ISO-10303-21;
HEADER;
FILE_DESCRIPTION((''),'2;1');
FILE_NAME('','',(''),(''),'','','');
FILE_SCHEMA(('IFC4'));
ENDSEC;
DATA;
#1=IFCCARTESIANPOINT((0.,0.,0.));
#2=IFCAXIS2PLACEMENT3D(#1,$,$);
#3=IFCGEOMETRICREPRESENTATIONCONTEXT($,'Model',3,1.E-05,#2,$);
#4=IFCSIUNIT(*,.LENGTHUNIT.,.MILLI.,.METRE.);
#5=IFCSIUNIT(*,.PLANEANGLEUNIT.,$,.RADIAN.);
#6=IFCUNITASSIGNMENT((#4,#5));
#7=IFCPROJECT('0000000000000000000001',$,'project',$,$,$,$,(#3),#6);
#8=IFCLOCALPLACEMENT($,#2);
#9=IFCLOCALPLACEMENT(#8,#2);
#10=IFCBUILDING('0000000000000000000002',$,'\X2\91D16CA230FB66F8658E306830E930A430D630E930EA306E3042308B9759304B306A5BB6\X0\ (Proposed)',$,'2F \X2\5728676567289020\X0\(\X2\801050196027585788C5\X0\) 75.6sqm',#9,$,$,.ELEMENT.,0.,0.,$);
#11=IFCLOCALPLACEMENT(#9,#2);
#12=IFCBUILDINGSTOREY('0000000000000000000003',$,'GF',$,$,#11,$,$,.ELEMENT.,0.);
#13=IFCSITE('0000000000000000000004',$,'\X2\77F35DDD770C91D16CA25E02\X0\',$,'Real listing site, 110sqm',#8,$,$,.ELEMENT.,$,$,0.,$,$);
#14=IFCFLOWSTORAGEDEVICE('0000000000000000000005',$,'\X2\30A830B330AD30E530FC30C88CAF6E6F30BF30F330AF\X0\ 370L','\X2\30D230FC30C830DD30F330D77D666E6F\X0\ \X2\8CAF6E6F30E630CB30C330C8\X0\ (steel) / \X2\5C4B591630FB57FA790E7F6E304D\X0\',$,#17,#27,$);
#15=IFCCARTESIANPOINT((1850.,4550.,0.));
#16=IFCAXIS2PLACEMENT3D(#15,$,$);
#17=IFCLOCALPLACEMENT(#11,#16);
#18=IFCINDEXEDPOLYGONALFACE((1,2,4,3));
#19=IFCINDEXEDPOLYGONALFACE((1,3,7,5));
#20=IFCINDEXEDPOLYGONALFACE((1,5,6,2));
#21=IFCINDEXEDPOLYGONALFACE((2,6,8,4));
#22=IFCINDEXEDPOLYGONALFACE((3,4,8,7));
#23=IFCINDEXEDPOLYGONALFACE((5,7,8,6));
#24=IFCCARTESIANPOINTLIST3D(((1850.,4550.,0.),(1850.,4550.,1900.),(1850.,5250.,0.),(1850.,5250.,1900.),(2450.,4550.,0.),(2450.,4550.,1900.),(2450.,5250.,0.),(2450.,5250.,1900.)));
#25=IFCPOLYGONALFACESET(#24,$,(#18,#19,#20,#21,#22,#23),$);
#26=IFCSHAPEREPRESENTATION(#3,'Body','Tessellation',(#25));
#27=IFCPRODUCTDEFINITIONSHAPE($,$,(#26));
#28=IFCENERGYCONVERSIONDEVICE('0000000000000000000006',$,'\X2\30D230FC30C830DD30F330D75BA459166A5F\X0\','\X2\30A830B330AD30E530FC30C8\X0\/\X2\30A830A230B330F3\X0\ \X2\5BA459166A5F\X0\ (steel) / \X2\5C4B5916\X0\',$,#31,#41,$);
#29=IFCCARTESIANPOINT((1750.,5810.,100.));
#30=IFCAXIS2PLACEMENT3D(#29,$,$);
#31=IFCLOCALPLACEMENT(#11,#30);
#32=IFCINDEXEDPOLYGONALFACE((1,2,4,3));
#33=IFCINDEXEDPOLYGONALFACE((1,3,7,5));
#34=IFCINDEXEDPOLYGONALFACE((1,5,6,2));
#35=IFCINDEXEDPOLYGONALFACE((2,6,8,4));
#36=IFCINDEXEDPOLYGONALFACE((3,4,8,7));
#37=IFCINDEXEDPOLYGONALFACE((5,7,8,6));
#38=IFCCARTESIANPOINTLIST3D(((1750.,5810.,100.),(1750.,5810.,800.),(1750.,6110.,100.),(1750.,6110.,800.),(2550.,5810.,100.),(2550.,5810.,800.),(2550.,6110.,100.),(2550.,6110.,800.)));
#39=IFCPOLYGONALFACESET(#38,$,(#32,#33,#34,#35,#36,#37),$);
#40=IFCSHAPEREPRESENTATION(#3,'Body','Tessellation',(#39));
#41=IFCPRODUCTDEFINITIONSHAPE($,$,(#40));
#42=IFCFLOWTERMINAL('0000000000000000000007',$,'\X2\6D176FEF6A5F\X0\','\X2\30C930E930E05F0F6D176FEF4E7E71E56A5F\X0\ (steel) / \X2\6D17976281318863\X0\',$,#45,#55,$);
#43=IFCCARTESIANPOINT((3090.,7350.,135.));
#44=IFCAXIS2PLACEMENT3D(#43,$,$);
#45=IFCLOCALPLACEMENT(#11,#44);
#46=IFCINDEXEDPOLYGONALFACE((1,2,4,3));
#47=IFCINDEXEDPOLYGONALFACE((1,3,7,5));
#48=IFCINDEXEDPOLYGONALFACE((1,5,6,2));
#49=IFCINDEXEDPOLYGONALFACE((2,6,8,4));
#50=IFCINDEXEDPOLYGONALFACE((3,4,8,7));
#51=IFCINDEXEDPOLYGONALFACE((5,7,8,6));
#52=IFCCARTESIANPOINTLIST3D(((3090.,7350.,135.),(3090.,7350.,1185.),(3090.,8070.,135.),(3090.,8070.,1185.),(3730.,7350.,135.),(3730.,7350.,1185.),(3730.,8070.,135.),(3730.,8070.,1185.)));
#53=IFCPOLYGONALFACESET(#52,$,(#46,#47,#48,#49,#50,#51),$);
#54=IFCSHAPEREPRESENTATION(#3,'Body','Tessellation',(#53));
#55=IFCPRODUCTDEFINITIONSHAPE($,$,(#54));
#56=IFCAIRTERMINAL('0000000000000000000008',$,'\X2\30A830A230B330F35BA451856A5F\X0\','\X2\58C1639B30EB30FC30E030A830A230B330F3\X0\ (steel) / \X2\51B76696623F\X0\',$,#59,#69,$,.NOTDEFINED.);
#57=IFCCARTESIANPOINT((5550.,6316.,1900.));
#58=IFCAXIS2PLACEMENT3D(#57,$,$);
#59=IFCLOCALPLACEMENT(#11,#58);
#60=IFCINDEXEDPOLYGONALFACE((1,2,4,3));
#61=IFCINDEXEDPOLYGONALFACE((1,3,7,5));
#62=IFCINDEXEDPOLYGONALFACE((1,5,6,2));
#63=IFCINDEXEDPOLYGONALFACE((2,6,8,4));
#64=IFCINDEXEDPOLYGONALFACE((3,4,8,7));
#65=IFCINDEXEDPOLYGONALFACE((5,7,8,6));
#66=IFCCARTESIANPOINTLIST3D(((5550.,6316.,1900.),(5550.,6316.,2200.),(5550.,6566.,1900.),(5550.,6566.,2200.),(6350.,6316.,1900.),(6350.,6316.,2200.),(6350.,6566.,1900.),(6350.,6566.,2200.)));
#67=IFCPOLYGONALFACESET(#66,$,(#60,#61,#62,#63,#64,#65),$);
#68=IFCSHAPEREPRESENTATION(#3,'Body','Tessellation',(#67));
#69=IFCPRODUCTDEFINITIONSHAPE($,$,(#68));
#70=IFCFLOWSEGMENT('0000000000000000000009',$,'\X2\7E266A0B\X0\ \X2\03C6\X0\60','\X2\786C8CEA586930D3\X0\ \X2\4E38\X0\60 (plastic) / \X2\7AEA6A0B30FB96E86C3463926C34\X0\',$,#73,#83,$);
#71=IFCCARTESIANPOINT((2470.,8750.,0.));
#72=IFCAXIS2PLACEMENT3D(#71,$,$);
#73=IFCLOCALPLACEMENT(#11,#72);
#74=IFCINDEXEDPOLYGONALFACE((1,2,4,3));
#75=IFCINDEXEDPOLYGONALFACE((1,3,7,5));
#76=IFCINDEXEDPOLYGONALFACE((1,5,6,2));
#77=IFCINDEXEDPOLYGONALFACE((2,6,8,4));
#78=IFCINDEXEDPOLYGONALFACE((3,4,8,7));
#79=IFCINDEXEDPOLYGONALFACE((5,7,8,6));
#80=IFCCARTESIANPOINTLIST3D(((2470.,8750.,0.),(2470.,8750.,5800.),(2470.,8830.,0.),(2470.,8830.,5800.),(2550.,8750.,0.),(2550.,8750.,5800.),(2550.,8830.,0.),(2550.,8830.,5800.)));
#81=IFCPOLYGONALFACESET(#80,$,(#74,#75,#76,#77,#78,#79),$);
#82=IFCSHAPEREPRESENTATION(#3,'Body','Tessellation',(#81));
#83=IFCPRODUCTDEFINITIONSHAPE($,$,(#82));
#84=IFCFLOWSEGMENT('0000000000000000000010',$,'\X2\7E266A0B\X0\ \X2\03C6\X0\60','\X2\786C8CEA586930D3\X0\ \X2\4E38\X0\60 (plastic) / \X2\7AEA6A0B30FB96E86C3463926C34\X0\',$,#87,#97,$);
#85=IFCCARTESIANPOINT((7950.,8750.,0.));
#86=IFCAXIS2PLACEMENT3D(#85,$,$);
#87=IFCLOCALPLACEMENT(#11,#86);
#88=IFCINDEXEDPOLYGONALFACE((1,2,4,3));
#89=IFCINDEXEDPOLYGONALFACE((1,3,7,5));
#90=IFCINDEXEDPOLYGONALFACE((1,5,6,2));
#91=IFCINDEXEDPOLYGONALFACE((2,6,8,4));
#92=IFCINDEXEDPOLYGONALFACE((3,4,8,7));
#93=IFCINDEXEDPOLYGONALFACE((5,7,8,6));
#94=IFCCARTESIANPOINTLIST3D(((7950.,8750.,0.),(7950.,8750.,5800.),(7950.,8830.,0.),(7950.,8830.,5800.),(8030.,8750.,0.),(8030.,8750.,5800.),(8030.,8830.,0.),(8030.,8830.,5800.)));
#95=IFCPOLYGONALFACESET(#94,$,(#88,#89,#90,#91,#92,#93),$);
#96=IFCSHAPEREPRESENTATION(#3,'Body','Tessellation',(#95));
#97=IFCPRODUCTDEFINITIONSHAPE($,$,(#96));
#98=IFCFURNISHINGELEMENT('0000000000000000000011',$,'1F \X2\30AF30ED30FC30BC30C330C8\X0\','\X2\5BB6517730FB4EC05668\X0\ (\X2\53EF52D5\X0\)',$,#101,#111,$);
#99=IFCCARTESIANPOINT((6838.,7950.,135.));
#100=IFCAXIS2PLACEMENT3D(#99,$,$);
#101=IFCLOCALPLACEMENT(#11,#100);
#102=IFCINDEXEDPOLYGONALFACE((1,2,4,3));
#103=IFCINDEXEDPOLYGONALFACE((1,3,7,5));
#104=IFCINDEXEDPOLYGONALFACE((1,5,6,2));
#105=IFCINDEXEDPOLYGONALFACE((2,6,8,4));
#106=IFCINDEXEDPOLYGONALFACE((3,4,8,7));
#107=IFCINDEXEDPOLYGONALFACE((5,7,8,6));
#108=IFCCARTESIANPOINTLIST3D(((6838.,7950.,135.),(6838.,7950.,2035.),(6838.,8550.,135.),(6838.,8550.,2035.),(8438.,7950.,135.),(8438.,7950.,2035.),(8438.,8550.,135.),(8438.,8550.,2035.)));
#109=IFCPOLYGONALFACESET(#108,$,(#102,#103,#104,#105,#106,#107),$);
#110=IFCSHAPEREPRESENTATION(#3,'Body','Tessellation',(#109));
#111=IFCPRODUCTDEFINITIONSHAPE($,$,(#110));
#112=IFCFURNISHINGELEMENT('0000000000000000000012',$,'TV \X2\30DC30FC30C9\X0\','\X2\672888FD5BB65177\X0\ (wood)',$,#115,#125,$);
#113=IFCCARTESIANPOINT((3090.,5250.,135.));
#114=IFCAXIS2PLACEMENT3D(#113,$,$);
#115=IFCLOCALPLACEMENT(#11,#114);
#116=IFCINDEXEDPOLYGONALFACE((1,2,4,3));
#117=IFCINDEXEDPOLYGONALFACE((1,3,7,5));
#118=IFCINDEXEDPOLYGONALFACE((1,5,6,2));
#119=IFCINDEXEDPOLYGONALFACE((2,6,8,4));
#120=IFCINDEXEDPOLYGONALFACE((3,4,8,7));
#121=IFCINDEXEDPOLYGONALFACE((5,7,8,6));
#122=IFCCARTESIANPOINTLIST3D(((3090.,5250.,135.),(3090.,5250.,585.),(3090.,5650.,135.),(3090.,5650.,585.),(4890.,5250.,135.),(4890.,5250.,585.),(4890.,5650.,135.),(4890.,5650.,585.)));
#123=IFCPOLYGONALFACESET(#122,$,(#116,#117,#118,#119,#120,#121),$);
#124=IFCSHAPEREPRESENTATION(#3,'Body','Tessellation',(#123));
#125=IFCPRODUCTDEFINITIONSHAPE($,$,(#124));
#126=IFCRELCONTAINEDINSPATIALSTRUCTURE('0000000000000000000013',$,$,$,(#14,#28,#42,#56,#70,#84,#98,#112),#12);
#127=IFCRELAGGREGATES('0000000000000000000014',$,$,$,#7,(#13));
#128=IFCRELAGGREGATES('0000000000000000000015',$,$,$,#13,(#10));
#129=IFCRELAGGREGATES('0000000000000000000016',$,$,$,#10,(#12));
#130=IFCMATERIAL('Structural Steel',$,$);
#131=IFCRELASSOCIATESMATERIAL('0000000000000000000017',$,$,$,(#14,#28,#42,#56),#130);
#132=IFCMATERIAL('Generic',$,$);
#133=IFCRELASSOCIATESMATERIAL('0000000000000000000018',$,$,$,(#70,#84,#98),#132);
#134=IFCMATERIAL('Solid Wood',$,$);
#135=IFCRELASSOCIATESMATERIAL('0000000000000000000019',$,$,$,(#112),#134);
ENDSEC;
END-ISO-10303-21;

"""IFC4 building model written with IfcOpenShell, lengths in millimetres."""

from ifc_helpers import new_model, si_unit, frame, frame_2d, origin, place, context, project, spatial, rectangle, extrude, material, element, save


model = new_model("IFC4")

# Units and contexts
model_context = context("Model", 3, precision=1e-05, world=origin())
ifc_project = project(units=[si_unit("LENGTHUNIT", "METRE", prefix="MILLI"), si_unit("PLANEANGLEUNIT", "RADIAN")], contexts=[model_context])

# Site, building, storey
site_placement = place(None, origin())
site = spatial("IfcSite", under=ifc_project, at=site_placement, Name="石川県金沢市", ObjectType="Real listing site, 110sqm", CompositionType="ELEMENT", RefElevation=0.0)
building_placement = place(site_placement, origin())
building = spatial("IfcBuilding", under=site, at=building_placement, Name="金沢・書斎とライブラリのある静かな家 (Proposed)", ObjectType="2F 在来木造(耐候性塗装) 75.6sqm", CompositionType="ELEMENT", ElevationOfRefHeight=0.0, ElevationOfTerrain=0.0)
storey_placement = place(building_placement, origin())
storey = spatial("IfcBuildingStorey", under=building, at=storey_placement, Name="GF", CompositionType="ELEMENT", Elevation=0.0)

# Shared definitions
ifc_material_1 = material(Name="Solid Wood")

# Shared definitions
ifc_material_2 = material(Name="Generic")

# Flow storage device
ifc_material_3 = material(Name="Structural Steel")
flow_storage_device_placement = place(storey_placement, frame((1850.0, 4550.0, 0.0)))
element("IfcFlowStorageDevice", 1, at=flow_storage_device_placement, inside=storey, material=ifc_material_3, Name="エコキュート貯湯タンク 370L", Description="ヒートポンプ給湯 貯湯ユニット (steel) / 屋外・基礎置き", context=model_context, shape_type="SweptSolid", body=[
    extrude(rectangle(XDim=600.0, YDim=700.0, at=frame_2d((300.0, 350.0))), frame((1850.0, 4550.0, 0.0)), (0.0, 0.0, 1.0), 1900.0),
])

# Energy conversion device
energy_conversion_device_placement = place(storey_placement, frame((1750.0, 5810.0, 100.0)))
element("IfcEnergyConversionDevice", 2, at=energy_conversion_device_placement, inside=storey, material=ifc_material_3, Name="ヒートポンプ室外機", Description="エコキュート/エアコン 室外機 (steel) / 屋外", context=model_context, shape_type="SweptSolid", body=[
    extrude(rectangle(XDim=800.0, YDim=300.0, at=frame_2d((400.0, 150.0))), frame((1750.0, 5810.0, 100.0)), (0.0, 0.0, 1.0), 700.0),
])

# Flow terminal
flow_terminal_placement = place(storey_placement, frame((3090.0, 7350.0, 135.0)))
element("IfcFlowTerminal", 3, at=flow_terminal_placement, inside=storey, material=ifc_material_3, Name="洗濯機", Description="ドラム式洗濯乾燥機 (steel) / 洗面脱衣", context=model_context, shape_type="SweptSolid", body=[
    extrude(rectangle(XDim=640.0, YDim=720.0, at=frame_2d((320.0, 360.0))), frame((3090.0, 7350.0, 135.0)), (0.0, 0.0, 1.0), 1050.0),
])

# Air terminal
air_terminal_placement = place(storey_placement, frame((5550.0, 6316.0, 1900.0)))
element("IfcAirTerminal", 4, at=air_terminal_placement, inside=storey, material=ifc_material_3, Name="エアコン室内機", Description="壁掛ルームエアコン (steel) / 冷暖房", PredefinedType="NOTDEFINED", context=model_context, shape_type="SweptSolid", body=[
    extrude(rectangle(XDim=800.0, YDim=250.0, at=frame_2d((400.0, 125.0))), frame((5550.0, 6316.0, 1900.0)), (0.0, 0.0, 1.0), 300.0),
])

# Flow segments
flow_segment_1_placement = place(storey_placement, frame((2470.0, 8750.0, 0.0)))
element("IfcFlowSegment", 5, at=flow_segment_1_placement, inside=storey, material=ifc_material_2, Name="縦樋 φ60", Description="硬質塩ビ 丸60 (plastic) / 竪樋・雨水排水", context=model_context, shape_type="SweptSolid", body=[
    extrude(rectangle(XDim=80.0, YDim=80.0, at=frame_2d((40.0, 40.0))), frame((2470.0, 8750.0, 0.0)), (0.0, 0.0, 1.0), 5800.0),
])
flow_segment_2_placement = place(storey_placement, frame((7950.0, 8750.0, 0.0)))
element("IfcFlowSegment", 6, at=flow_segment_2_placement, inside=storey, material=ifc_material_2, Name="縦樋 φ60", Description="硬質塩ビ 丸60 (plastic) / 竪樋・雨水排水", context=model_context, shape_type="SweptSolid", body=[
    extrude(rectangle(XDim=80.0, YDim=80.0, at=frame_2d((40.0, 40.0))), frame((7950.0, 8750.0, 0.0)), (0.0, 0.0, 1.0), 5800.0),
])

# Furnishing elements
furnishing_1_placement = place(storey_placement, frame((6838.0, 7950.0, 135.0)))
element("IfcFurnishingElement", 7, at=furnishing_1_placement, inside=storey, material=ifc_material_2, Name="1F クローゼット", Description="家具・什器 (可動)", context=model_context, shape_type="SweptSolid", body=[
    extrude(rectangle(XDim=1600.0, YDim=600.0, at=frame_2d((800.0, 300.0))), frame((6838.0, 7950.0, 135.0)), (0.0, 0.0, 1.0), 1900.0),
])
furnishing_2_placement = place(storey_placement, frame((3090.0, 5250.0, 135.0)))
element("IfcFurnishingElement", 8, at=furnishing_2_placement, inside=storey, material=ifc_material_1, Name="TV ボード", Description="木製家具 (wood)", context=model_context, shape_type="SweptSolid", body=[
    extrude(rectangle(XDim=1800.0, YDim=400.0, at=frame_2d((900.0, 200.0))), frame((3090.0, 5250.0, 135.0)), (0.0, 0.0, 1.0), 450.0),
])

save(model, "model.ifc")
